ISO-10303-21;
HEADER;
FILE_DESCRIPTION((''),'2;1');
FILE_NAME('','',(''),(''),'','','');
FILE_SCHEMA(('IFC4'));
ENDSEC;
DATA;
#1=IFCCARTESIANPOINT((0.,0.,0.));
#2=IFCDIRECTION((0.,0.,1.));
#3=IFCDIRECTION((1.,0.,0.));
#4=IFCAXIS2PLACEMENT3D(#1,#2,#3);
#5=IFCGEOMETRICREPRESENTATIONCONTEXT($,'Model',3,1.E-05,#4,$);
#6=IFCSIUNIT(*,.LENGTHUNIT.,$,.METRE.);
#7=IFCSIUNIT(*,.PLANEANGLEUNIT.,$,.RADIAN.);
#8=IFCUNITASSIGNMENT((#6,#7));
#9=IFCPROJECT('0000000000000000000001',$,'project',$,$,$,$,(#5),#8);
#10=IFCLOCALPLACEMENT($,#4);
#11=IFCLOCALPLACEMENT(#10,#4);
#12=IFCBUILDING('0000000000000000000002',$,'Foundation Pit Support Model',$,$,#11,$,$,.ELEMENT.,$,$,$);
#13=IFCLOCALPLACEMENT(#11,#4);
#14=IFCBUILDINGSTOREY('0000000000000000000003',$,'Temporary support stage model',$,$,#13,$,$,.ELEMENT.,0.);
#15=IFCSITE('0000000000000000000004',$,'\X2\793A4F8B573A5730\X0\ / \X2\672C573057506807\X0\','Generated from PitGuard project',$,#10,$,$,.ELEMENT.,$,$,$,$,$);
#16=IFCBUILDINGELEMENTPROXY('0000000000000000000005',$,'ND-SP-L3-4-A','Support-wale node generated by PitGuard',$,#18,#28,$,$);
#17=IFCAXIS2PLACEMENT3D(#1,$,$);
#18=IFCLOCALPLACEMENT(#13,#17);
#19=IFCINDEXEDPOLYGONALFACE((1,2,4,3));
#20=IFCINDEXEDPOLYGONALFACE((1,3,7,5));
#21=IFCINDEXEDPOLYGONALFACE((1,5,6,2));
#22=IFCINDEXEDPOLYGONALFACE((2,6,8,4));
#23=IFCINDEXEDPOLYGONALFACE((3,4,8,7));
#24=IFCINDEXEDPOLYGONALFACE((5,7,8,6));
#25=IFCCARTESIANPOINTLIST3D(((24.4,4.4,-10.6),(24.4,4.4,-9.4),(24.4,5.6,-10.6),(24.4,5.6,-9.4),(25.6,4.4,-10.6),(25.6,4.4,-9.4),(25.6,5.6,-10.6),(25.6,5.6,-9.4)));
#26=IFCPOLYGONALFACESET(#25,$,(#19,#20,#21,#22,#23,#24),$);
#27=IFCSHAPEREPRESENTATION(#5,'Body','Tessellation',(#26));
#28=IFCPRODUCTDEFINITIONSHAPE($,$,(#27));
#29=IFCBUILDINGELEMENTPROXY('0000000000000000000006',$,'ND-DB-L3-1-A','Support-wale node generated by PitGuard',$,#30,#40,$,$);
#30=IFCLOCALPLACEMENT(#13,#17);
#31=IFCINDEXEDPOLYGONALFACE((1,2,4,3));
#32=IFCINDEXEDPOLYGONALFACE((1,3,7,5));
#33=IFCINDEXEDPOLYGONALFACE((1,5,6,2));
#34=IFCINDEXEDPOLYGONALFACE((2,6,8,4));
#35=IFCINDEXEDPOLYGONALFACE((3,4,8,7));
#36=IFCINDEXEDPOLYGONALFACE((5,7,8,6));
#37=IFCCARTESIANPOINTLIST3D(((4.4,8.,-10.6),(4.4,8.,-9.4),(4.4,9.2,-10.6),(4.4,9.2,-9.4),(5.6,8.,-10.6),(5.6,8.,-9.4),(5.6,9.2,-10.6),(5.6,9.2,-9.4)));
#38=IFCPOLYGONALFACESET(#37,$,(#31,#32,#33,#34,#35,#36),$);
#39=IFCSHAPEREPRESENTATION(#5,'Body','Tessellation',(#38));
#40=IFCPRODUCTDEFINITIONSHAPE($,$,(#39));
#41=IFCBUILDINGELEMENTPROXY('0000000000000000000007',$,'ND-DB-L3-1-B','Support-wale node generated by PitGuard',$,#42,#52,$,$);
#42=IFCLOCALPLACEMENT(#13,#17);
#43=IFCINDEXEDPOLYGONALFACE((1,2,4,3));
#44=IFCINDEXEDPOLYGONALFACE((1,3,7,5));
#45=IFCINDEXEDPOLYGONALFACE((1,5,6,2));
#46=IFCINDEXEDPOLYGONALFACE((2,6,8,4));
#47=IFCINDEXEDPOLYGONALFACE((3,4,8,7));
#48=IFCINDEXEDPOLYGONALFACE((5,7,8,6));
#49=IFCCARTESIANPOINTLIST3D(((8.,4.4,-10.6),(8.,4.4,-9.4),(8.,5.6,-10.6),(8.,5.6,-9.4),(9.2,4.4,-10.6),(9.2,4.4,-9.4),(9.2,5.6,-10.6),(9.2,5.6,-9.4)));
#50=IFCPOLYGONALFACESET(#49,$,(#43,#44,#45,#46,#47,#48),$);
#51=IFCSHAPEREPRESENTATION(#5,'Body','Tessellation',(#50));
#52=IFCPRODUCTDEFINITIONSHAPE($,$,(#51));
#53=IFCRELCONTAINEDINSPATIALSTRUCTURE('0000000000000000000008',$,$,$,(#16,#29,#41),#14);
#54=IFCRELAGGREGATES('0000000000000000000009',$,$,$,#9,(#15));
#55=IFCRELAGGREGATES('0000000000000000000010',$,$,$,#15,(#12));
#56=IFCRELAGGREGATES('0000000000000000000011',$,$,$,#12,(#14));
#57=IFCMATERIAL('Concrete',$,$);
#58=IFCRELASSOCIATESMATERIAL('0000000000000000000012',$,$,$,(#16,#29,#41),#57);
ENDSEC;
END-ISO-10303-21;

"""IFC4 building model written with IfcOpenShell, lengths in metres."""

from ifc_helpers import new_model, si_unit, frame, origin_with_axes, origin_2d, place, context, project, spatial, rectangle, extrude, material, element, save


model = new_model("IFC4")

# Units and contexts
model_context = context("Model", 3, precision=1e-05, world=origin_with_axes())
ifc_project = project(units=[si_unit("LENGTHUNIT", "METRE"), si_unit("PLANEANGLEUNIT", "RADIAN")], contexts=[model_context])

# Site, building, storey
site_placement = place(None, origin_with_axes())
site = spatial("IfcSite", under=ifc_project, at=site_placement, Name="示例场地 / 本地坐标", Description="Generated from PitGuard project", CompositionType="ELEMENT")
building_placement = place(site_placement, origin_with_axes())
building = spatial("IfcBuilding", under=site, at=building_placement, Name="Foundation Pit Support Model", CompositionType="ELEMENT")
storey_placement = place(building_placement, origin_with_axes())
storey = spatial("IfcBuildingStorey", under=building, at=storey_placement, Name="Temporary support stage model", CompositionType="ELEMENT", Elevation=0.0)

# Shared definitions
ifc_material_1 = material(Name="Concrete")

# Building element proxies
for number, where, z_axis, x_axis, name in (
    (1, (25.0, 5.0, -10.6), (0.0, 0.0, 1.0), (1.0, 0.0, 0.0), "ND-SP-L3-4-A"),
    (2, (5.0, 8.6, -10.6), (0.0, 0.0, 1.0), (1.0, 0.0, 0.0), "ND-DB-L3-1-A"),
    (3, (8.6, 5.0, -10.6), (0.0, 0.0, 1.0), (1.0, 0.0, 0.0), "ND-DB-L3-1-B"),
):
    element("IfcBuildingElementProxy", number, at=place(storey_placement, frame(where, z_axis=z_axis, x_axis=x_axis)), inside=storey, material=ifc_material_1, Name=name, Description="Support-wale node generated by PitGuard", context=model_context, shape_type="SweptSolid", body=[
        extrude(rectangle(XDim=1.2, YDim=1.2, at=origin_2d()), origin_with_axes(), (0.0, 0.0, 1.0), 1.2),
    ])

save(model, "model.ifc")
